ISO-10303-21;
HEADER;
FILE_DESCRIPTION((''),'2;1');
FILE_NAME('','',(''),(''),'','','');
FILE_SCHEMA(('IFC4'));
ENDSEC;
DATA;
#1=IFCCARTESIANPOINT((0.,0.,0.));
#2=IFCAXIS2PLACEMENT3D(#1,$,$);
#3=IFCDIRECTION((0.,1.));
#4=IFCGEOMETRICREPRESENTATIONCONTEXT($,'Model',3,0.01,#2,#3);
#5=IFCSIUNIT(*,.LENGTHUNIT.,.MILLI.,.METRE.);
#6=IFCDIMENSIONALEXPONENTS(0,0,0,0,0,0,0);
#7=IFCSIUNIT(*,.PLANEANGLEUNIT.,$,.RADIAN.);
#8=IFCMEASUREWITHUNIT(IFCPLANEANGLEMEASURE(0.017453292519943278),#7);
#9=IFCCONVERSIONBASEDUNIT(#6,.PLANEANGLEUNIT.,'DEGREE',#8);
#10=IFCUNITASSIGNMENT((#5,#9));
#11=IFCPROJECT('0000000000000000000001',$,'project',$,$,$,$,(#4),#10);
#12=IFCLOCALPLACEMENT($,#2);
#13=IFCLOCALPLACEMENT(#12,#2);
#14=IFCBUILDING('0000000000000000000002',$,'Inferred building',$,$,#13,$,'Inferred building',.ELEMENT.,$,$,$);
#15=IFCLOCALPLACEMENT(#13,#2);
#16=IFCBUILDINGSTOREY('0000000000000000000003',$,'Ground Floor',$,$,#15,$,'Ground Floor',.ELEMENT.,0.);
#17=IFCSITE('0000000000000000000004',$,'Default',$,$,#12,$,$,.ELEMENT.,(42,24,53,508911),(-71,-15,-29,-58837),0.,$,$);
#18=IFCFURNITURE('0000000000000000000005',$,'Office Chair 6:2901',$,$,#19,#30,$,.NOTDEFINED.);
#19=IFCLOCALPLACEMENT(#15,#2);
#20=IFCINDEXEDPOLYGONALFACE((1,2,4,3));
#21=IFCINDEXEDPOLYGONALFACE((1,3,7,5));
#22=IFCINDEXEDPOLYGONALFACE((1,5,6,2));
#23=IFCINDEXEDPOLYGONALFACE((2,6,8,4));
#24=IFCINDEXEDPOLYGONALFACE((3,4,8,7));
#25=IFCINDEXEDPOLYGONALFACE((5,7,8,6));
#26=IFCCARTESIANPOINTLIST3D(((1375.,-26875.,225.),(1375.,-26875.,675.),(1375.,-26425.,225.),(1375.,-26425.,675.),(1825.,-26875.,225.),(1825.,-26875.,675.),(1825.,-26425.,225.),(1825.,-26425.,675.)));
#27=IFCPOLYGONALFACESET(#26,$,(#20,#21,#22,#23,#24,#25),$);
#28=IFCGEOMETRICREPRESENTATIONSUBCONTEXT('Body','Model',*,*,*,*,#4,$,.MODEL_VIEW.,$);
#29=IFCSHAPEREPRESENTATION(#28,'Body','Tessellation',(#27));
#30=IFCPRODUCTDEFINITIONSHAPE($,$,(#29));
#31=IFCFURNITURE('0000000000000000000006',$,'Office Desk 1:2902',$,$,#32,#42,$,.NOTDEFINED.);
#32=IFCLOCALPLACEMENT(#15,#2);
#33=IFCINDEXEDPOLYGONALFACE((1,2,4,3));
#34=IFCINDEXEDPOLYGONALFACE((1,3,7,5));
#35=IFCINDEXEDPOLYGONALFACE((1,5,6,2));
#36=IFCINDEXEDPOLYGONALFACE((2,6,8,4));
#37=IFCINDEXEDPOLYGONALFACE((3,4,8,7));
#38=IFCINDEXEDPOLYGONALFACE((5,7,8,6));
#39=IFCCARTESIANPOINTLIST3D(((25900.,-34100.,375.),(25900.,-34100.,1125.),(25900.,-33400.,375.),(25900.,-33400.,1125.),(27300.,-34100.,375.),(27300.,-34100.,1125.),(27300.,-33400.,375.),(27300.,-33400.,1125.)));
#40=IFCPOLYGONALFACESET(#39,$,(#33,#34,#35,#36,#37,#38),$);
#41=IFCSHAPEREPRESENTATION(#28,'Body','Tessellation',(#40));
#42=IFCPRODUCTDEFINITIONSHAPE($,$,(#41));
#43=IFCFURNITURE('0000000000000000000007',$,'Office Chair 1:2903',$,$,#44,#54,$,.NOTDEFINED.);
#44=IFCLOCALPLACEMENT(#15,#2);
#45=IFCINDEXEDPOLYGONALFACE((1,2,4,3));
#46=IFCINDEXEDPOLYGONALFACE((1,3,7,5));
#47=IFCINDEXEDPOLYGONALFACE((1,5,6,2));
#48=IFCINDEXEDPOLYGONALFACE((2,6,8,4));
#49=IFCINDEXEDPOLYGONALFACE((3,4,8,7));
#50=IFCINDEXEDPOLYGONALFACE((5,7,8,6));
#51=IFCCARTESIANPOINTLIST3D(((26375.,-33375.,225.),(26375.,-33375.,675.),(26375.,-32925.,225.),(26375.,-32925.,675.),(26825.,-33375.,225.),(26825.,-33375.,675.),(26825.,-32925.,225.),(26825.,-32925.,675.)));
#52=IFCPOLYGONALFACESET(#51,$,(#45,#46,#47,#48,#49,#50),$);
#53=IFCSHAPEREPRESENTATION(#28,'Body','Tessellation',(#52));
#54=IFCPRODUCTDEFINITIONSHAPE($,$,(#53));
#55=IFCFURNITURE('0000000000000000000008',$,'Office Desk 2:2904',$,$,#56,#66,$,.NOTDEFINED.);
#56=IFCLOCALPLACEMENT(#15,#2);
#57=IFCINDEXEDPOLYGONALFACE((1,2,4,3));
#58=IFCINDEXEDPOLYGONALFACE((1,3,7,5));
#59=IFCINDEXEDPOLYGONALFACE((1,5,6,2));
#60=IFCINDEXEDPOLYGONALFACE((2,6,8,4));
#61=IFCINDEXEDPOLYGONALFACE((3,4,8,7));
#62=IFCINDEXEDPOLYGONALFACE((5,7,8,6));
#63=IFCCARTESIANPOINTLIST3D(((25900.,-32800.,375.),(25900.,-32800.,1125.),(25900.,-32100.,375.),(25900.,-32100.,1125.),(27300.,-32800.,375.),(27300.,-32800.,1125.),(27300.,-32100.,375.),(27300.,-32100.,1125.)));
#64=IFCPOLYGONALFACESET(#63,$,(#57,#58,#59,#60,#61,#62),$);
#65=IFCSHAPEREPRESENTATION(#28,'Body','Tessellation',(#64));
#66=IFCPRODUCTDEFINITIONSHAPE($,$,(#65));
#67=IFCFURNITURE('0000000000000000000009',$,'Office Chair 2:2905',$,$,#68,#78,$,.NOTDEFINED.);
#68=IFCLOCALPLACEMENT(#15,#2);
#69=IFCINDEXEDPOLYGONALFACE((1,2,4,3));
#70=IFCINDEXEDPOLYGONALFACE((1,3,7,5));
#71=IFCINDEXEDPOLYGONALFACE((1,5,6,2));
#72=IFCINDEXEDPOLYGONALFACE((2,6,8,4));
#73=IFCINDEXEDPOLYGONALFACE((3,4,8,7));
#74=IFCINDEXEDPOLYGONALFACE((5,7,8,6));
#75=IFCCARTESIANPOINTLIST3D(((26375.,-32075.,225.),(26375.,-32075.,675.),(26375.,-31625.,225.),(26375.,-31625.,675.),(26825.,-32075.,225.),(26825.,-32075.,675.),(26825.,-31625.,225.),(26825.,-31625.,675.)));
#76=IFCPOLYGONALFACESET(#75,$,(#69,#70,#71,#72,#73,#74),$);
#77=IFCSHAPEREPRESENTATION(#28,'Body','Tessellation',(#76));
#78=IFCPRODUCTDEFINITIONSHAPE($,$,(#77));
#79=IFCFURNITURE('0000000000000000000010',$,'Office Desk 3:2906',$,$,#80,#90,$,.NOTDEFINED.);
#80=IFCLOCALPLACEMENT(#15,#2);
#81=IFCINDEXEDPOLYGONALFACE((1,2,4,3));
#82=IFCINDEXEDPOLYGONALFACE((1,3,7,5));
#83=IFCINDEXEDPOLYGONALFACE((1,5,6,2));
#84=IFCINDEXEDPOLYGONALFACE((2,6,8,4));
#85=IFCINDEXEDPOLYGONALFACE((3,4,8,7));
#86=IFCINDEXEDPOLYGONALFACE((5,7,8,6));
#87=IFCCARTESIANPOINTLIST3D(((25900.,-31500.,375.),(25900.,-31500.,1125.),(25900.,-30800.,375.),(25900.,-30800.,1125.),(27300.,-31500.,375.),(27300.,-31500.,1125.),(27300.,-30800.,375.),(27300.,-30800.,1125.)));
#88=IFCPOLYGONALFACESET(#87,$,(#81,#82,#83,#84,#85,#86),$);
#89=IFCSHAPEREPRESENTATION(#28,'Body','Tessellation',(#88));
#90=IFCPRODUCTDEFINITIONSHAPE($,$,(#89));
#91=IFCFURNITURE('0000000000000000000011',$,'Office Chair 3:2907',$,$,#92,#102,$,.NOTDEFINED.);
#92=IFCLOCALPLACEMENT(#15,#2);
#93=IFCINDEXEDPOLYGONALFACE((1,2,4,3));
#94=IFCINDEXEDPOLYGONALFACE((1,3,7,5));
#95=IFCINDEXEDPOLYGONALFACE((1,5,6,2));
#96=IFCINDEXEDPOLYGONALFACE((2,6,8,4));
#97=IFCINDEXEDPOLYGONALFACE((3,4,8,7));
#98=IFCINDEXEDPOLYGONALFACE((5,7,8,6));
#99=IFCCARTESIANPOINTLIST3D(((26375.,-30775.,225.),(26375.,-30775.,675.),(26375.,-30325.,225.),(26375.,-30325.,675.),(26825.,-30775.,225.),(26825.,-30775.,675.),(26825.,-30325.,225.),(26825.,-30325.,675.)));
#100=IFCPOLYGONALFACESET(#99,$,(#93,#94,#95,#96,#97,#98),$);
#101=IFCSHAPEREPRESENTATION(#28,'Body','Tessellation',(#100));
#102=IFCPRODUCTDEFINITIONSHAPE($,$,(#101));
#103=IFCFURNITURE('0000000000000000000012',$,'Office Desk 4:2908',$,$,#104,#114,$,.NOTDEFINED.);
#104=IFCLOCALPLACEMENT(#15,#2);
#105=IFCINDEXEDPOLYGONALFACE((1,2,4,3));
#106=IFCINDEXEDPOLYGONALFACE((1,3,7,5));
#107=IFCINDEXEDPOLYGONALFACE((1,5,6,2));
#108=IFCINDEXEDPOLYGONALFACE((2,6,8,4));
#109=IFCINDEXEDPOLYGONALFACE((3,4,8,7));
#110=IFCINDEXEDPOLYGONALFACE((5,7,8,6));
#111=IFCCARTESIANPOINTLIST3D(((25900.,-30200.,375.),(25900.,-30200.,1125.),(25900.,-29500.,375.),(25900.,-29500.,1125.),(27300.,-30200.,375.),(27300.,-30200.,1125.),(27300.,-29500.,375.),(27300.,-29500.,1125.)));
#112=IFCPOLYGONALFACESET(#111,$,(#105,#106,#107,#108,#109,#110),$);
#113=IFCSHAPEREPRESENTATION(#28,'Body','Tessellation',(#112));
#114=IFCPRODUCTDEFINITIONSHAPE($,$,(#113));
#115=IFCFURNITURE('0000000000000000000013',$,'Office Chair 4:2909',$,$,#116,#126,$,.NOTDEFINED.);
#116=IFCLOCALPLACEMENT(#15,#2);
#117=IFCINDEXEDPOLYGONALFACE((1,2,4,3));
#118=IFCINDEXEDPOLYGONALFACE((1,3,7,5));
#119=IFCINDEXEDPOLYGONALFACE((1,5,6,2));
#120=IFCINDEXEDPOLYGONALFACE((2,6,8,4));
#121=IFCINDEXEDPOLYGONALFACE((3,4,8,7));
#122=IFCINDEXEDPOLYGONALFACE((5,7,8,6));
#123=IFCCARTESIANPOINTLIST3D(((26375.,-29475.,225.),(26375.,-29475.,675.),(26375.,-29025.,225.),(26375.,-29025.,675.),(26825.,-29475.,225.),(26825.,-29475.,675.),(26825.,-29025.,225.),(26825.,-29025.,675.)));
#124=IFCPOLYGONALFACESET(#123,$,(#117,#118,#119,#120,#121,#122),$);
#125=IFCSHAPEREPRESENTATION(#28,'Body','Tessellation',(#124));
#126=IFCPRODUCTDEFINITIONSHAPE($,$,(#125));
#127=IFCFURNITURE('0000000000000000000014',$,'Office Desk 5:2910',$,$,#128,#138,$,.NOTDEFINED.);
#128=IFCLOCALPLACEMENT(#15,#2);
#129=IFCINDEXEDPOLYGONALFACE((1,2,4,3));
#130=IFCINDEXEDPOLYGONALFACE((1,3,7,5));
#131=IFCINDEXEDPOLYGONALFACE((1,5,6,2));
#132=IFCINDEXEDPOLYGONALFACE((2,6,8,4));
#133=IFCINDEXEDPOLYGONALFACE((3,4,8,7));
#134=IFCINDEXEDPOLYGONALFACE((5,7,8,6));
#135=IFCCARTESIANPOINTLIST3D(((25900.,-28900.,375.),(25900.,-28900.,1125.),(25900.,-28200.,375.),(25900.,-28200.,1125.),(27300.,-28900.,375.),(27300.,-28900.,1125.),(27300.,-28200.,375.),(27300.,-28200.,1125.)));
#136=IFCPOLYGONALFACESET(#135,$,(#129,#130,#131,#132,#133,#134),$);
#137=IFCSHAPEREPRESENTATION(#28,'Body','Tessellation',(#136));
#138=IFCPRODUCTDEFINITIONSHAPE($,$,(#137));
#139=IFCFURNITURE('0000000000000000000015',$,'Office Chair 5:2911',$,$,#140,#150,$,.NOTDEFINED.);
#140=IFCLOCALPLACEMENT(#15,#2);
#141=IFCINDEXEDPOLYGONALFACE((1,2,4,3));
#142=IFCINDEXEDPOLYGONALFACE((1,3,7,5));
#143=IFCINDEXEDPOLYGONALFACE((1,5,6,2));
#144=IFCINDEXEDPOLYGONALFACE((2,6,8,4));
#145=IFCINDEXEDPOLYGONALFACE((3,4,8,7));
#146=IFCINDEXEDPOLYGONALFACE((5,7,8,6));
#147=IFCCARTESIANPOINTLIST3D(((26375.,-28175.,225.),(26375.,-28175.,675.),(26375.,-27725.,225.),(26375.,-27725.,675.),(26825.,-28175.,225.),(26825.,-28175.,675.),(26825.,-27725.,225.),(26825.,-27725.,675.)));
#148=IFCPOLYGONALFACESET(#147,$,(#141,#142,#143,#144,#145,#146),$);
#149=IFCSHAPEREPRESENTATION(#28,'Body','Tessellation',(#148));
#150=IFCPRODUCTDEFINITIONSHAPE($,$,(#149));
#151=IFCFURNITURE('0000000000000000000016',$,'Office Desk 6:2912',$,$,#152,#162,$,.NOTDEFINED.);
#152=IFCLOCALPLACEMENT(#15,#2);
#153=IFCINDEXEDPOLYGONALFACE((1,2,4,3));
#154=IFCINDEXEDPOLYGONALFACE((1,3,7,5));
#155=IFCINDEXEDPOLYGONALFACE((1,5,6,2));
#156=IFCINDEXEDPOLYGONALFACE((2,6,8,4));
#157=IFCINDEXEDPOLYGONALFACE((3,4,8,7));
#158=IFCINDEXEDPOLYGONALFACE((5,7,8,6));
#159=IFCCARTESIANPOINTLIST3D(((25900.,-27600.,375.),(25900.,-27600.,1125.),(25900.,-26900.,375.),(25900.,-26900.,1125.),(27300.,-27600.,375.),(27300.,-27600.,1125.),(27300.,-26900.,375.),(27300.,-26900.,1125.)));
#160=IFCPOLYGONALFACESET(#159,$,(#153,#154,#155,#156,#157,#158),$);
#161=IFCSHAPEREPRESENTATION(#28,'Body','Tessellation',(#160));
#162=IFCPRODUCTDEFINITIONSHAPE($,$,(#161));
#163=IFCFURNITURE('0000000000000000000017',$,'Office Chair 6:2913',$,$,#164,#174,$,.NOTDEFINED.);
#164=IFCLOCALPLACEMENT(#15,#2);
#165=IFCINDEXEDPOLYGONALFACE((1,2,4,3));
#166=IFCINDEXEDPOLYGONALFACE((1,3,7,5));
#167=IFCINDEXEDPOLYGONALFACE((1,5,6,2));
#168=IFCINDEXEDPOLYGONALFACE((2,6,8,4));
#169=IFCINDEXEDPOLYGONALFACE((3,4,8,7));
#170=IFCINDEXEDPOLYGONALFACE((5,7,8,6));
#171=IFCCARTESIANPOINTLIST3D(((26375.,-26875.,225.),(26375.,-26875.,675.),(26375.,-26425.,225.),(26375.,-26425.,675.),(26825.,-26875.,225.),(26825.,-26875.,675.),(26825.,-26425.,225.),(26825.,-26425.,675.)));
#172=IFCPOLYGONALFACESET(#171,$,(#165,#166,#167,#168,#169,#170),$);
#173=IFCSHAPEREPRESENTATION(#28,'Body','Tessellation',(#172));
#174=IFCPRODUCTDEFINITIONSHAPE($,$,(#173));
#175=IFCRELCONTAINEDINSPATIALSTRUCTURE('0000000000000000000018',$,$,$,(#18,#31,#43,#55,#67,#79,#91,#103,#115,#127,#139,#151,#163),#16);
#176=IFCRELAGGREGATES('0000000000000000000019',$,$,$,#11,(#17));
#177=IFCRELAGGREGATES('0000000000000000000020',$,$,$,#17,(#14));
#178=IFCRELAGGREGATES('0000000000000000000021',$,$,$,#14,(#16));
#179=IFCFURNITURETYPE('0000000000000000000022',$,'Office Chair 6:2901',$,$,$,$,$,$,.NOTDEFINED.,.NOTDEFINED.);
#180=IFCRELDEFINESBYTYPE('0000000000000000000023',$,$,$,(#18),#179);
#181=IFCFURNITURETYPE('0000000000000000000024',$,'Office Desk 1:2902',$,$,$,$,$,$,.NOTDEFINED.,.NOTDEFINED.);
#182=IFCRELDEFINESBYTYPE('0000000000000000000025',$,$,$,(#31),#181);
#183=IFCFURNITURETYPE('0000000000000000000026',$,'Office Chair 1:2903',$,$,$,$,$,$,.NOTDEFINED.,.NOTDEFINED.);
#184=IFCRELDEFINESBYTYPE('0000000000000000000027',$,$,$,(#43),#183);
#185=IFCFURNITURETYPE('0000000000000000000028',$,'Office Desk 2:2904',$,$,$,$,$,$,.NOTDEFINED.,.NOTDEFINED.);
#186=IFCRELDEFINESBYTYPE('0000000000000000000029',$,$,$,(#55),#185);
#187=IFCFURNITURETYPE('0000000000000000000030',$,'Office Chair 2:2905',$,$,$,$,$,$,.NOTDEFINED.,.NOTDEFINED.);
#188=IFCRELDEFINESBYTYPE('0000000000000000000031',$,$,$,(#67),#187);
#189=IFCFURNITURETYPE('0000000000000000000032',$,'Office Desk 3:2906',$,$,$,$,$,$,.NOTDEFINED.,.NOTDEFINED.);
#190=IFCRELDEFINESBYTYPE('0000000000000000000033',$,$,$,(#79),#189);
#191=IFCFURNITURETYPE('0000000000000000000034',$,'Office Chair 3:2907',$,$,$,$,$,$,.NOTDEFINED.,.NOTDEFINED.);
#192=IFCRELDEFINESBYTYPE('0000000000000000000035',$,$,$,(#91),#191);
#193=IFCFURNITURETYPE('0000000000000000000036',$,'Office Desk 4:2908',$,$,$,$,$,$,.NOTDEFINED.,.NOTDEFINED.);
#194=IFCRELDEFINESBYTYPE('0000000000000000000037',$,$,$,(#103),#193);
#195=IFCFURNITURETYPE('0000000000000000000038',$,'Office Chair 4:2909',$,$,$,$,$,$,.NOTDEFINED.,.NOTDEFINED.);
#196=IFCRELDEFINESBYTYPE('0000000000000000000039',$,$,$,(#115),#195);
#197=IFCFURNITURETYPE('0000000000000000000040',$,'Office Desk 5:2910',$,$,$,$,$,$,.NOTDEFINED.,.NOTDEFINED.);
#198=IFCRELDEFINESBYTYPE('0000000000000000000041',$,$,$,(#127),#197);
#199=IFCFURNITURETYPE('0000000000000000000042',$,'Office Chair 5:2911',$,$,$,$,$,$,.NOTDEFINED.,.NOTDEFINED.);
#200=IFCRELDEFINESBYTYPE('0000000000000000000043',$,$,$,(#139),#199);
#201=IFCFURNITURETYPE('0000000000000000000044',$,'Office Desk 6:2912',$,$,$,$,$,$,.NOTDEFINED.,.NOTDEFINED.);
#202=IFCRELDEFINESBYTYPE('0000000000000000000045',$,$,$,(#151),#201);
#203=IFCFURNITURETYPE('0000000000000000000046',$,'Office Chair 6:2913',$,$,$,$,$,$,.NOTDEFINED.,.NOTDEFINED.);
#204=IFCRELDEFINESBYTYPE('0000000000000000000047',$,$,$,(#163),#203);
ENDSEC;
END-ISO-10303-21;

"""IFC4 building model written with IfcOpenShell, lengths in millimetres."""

from ifc_helpers import new_model, entity, si_unit, converted_unit, direction, frame, origin, origin_2d_with_axis, place, context, subcontext, project, spatial, rectangle, extrude, type_object, element, save


model = new_model("IFC4")

# Units and contexts
model_context = context("Model", 3, precision=0.01, world=origin(), true_north=direction((0.0, 1.0)))
body_context = subcontext(model_context, "Body", "Model", "MODEL_VIEW")
ifc_project = project(units=[si_unit("LENGTHUNIT", "METRE", prefix="MILLI"), converted_unit("PLANEANGLEUNIT", "DEGREE", entity("IfcPlaneAngleMeasure", 0.017453292519943278), si_unit("PLANEANGLEUNIT", "RADIAN"), dimensions=[0, 0, 0, 0, 0, 0, 0])], contexts=[model_context])

# Site, building, storey
site_placement = place(None, origin())
site = spatial("IfcSite", under=ifc_project, at=site_placement, Name="Default", CompositionType="ELEMENT", RefLatitude=(42, 24, 53, 508911), RefLongitude=(-71, -15, -29, -58837), RefElevation=0.0)
building_placement = place(site_placement, origin())
building = spatial("IfcBuilding", under=site, at=building_placement, Name="Inferred building", LongName="Inferred building", CompositionType="ELEMENT")
storey_placement = place(building_placement, origin())
storey = spatial("IfcBuildingStorey", under=building, at=storey_placement, Name="Ground Floor", LongName="Ground Floor", CompositionType="ELEMENT", Elevation=0.0)

# Furniture
furniture_type_1 = type_object("IfcFurnitureType", Name="Office Chair 6:2901", PredefinedType="NOTDEFINED")
furniture_1_placement = place(storey_placement, origin())
element("IfcFurniture", 1, at=furniture_1_placement, inside=storey, type_object=furniture_type_1, Name="Office Chair 6:2901", PredefinedType="NOTDEFINED", context=body_context, shape_type="SweptSolid", body=[
    extrude(rectangle(XDim=450.0, YDim=450.0, at=origin_2d_with_axis()), frame((1600.0, -26650.0, 225.0)), (0.0, 0.0, 1.0), 450.0),
])
furniture_type_2 = type_object("IfcFurnitureType", Name="Office Desk 1:2902", PredefinedType="NOTDEFINED")
furniture_2_placement = place(storey_placement, origin())
element("IfcFurniture", 2, at=furniture_2_placement, inside=storey, type_object=furniture_type_2, Name="Office Desk 1:2902", PredefinedType="NOTDEFINED", context=body_context, shape_type="SweptSolid", body=[
    extrude(rectangle(XDim=1400.0, YDim=700.0, at=origin_2d_with_axis()), frame((26600.0, -33750.0, 375.0)), (0.0, 0.0, 1.0), 750.0),
])
furniture_type_3 = type_object("IfcFurnitureType", Name="Office Chair 1:2903", PredefinedType="NOTDEFINED")
furniture_3_placement = place(storey_placement, origin())
element("IfcFurniture", 3, at=furniture_3_placement, inside=storey, type_object=furniture_type_3, Name="Office Chair 1:2903", PredefinedType="NOTDEFINED", context=body_context, shape_type="SweptSolid", body=[
    extrude(rectangle(XDim=450.0, YDim=450.0, at=origin_2d_with_axis()), frame((26600.0, -33150.0, 225.0)), (0.0, 0.0, 1.0), 450.0),
])
furniture_type_4 = type_object("IfcFurnitureType", Name="Office Desk 2:2904", PredefinedType="NOTDEFINED")
furniture_4_placement = place(storey_placement, origin())
element("IfcFurniture", 4, at=furniture_4_placement, inside=storey, type_object=furniture_type_4, Name="Office Desk 2:2904", PredefinedType="NOTDEFINED", context=body_context, shape_type="SweptSolid", body=[
    extrude(rectangle(XDim=1400.0, YDim=700.0, at=origin_2d_with_axis()), frame((26600.0, -32450.0, 375.0)), (0.0, 0.0, 1.0), 750.0),
])
furniture_type_5 = type_object("IfcFurnitureType", Name="Office Chair 2:2905", PredefinedType="NOTDEFINED")
furniture_5_placement = place(storey_placement, origin())
element("IfcFurniture", 5, at=furniture_5_placement, inside=storey, type_object=furniture_type_5, Name="Office Chair 2:2905", PredefinedType="NOTDEFINED", context=body_context, shape_type="SweptSolid", body=[
    extrude(rectangle(XDim=450.0, YDim=450.0, at=origin_2d_with_axis()), frame((26600.0, -31850.0, 225.0)), (0.0, 0.0, 1.0), 450.0),
])
furniture_type_6 = type_object("IfcFurnitureType", Name="Office Desk 3:2906", PredefinedType="NOTDEFINED")
furniture_6_placement = place(storey_placement, origin())
element("IfcFurniture", 6, at=furniture_6_placement, inside=storey, type_object=furniture_type_6, Name="Office Desk 3:2906", PredefinedType="NOTDEFINED", context=body_context, shape_type="SweptSolid", body=[
    extrude(rectangle(XDim=1400.0, YDim=700.0, at=origin_2d_with_axis()), frame((26600.0, -31150.0, 375.0)), (0.0, 0.0, 1.0), 750.0),
])
furniture_type_7 = type_object("IfcFurnitureType", Name="Office Chair 3:2907", PredefinedType="NOTDEFINED")
furniture_7_placement = place(storey_placement, origin())
element("IfcFurniture", 7, at=furniture_7_placement, inside=storey, type_object=furniture_type_7, Name="Office Chair 3:2907", PredefinedType="NOTDEFINED", context=body_context, shape_type="SweptSolid", body=[
    extrude(rectangle(XDim=450.0, YDim=450.0, at=origin_2d_with_axis()), frame((26600.0, -30550.0, 225.0)), (0.0, 0.0, 1.0), 450.0),
])
furniture_type_8 = type_object("IfcFurnitureType", Name="Office Desk 4:2908", PredefinedType="NOTDEFINED")
furniture_8_placement = place(storey_placement, origin())
element("IfcFurniture", 8, at=furniture_8_placement, inside=storey, type_object=furniture_type_8, Name="Office Desk 4:2908", PredefinedType="NOTDEFINED", context=body_context, shape_type="SweptSolid", body=[
    extrude(rectangle(XDim=1400.0, YDim=700.0, at=origin_2d_with_axis()), frame((26600.0, -29850.0, 375.0)), (0.0, 0.0, 1.0), 750.0),
])
furniture_type_9 = type_object("IfcFurnitureType", Name="Office Chair 4:2909", PredefinedType="NOTDEFINED")
furniture_9_placement = place(storey_placement, origin())
element("IfcFurniture", 9, at=furniture_9_placement, inside=storey, type_object=furniture_type_9, Name="Office Chair 4:2909", PredefinedType="NOTDEFINED", context=body_context, shape_type="SweptSolid", body=[
    extrude(rectangle(XDim=450.0, YDim=450.0, at=origin_2d_with_axis()), frame((26600.0, -29250.0, 225.0)), (0.0, 0.0, 1.0), 450.0),
])
furniture_type_10 = type_object("IfcFurnitureType", Name="Office Desk 5:2910", PredefinedType="NOTDEFINED")
furniture_10_placement = place(storey_placement, origin())
element("IfcFurniture", 10, at=furniture_10_placement, inside=storey, type_object=furniture_type_10, Name="Office Desk 5:2910", PredefinedType="NOTDEFINED", context=body_context, shape_type="SweptSolid", body=[
    extrude(rectangle(XDim=1400.0, YDim=700.0, at=origin_2d_with_axis()), frame((26600.0, -28550.0, 375.0)), (0.0, 0.0, 1.0), 750.0),
])
furniture_type_11 = type_object("IfcFurnitureType", Name="Office Chair 5:2911", PredefinedType="NOTDEFINED")
furniture_11_placement = place(storey_placement, origin())
element("IfcFurniture", 11, at=furniture_11_placement, inside=storey, type_object=furniture_type_11, Name="Office Chair 5:2911", PredefinedType="NOTDEFINED", context=body_context, shape_type="SweptSolid", body=[
    extrude(rectangle(XDim=450.0, YDim=450.0, at=origin_2d_with_axis()), frame((26600.0, -27950.0, 225.0)), (0.0, 0.0, 1.0), 450.0),
])
furniture_type_12 = type_object("IfcFurnitureType", Name="Office Desk 6:2912", PredefinedType="NOTDEFINED")
furniture_12_placement = place(storey_placement, origin())
element("IfcFurniture", 12, at=furniture_12_placement, inside=storey, type_object=furniture_type_12, Name="Office Desk 6:2912", PredefinedType="NOTDEFINED", context=body_context, shape_type="SweptSolid", body=[
    extrude(rectangle(XDim=1400.0, YDim=700.0, at=origin_2d_with_axis()), frame((26600.0, -27250.0, 375.0)), (0.0, 0.0, 1.0), 750.0),
])
furniture_type_13 = type_object("IfcFurnitureType", Name="Office Chair 6:2913", PredefinedType="NOTDEFINED")
furniture_13_placement = place(storey_placement, origin())
element("IfcFurniture", 13, at=furniture_13_placement, inside=storey, type_object=furniture_type_13, Name="Office Chair 6:2913", PredefinedType="NOTDEFINED", context=body_context, shape_type="SweptSolid", body=[
    extrude(rectangle(XDim=450.0, YDim=450.0, at=origin_2d_with_axis()), frame((26600.0, -26650.0, 225.0)), (0.0, 0.0, 1.0), 450.0),
])

save(model, "model.ifc")
